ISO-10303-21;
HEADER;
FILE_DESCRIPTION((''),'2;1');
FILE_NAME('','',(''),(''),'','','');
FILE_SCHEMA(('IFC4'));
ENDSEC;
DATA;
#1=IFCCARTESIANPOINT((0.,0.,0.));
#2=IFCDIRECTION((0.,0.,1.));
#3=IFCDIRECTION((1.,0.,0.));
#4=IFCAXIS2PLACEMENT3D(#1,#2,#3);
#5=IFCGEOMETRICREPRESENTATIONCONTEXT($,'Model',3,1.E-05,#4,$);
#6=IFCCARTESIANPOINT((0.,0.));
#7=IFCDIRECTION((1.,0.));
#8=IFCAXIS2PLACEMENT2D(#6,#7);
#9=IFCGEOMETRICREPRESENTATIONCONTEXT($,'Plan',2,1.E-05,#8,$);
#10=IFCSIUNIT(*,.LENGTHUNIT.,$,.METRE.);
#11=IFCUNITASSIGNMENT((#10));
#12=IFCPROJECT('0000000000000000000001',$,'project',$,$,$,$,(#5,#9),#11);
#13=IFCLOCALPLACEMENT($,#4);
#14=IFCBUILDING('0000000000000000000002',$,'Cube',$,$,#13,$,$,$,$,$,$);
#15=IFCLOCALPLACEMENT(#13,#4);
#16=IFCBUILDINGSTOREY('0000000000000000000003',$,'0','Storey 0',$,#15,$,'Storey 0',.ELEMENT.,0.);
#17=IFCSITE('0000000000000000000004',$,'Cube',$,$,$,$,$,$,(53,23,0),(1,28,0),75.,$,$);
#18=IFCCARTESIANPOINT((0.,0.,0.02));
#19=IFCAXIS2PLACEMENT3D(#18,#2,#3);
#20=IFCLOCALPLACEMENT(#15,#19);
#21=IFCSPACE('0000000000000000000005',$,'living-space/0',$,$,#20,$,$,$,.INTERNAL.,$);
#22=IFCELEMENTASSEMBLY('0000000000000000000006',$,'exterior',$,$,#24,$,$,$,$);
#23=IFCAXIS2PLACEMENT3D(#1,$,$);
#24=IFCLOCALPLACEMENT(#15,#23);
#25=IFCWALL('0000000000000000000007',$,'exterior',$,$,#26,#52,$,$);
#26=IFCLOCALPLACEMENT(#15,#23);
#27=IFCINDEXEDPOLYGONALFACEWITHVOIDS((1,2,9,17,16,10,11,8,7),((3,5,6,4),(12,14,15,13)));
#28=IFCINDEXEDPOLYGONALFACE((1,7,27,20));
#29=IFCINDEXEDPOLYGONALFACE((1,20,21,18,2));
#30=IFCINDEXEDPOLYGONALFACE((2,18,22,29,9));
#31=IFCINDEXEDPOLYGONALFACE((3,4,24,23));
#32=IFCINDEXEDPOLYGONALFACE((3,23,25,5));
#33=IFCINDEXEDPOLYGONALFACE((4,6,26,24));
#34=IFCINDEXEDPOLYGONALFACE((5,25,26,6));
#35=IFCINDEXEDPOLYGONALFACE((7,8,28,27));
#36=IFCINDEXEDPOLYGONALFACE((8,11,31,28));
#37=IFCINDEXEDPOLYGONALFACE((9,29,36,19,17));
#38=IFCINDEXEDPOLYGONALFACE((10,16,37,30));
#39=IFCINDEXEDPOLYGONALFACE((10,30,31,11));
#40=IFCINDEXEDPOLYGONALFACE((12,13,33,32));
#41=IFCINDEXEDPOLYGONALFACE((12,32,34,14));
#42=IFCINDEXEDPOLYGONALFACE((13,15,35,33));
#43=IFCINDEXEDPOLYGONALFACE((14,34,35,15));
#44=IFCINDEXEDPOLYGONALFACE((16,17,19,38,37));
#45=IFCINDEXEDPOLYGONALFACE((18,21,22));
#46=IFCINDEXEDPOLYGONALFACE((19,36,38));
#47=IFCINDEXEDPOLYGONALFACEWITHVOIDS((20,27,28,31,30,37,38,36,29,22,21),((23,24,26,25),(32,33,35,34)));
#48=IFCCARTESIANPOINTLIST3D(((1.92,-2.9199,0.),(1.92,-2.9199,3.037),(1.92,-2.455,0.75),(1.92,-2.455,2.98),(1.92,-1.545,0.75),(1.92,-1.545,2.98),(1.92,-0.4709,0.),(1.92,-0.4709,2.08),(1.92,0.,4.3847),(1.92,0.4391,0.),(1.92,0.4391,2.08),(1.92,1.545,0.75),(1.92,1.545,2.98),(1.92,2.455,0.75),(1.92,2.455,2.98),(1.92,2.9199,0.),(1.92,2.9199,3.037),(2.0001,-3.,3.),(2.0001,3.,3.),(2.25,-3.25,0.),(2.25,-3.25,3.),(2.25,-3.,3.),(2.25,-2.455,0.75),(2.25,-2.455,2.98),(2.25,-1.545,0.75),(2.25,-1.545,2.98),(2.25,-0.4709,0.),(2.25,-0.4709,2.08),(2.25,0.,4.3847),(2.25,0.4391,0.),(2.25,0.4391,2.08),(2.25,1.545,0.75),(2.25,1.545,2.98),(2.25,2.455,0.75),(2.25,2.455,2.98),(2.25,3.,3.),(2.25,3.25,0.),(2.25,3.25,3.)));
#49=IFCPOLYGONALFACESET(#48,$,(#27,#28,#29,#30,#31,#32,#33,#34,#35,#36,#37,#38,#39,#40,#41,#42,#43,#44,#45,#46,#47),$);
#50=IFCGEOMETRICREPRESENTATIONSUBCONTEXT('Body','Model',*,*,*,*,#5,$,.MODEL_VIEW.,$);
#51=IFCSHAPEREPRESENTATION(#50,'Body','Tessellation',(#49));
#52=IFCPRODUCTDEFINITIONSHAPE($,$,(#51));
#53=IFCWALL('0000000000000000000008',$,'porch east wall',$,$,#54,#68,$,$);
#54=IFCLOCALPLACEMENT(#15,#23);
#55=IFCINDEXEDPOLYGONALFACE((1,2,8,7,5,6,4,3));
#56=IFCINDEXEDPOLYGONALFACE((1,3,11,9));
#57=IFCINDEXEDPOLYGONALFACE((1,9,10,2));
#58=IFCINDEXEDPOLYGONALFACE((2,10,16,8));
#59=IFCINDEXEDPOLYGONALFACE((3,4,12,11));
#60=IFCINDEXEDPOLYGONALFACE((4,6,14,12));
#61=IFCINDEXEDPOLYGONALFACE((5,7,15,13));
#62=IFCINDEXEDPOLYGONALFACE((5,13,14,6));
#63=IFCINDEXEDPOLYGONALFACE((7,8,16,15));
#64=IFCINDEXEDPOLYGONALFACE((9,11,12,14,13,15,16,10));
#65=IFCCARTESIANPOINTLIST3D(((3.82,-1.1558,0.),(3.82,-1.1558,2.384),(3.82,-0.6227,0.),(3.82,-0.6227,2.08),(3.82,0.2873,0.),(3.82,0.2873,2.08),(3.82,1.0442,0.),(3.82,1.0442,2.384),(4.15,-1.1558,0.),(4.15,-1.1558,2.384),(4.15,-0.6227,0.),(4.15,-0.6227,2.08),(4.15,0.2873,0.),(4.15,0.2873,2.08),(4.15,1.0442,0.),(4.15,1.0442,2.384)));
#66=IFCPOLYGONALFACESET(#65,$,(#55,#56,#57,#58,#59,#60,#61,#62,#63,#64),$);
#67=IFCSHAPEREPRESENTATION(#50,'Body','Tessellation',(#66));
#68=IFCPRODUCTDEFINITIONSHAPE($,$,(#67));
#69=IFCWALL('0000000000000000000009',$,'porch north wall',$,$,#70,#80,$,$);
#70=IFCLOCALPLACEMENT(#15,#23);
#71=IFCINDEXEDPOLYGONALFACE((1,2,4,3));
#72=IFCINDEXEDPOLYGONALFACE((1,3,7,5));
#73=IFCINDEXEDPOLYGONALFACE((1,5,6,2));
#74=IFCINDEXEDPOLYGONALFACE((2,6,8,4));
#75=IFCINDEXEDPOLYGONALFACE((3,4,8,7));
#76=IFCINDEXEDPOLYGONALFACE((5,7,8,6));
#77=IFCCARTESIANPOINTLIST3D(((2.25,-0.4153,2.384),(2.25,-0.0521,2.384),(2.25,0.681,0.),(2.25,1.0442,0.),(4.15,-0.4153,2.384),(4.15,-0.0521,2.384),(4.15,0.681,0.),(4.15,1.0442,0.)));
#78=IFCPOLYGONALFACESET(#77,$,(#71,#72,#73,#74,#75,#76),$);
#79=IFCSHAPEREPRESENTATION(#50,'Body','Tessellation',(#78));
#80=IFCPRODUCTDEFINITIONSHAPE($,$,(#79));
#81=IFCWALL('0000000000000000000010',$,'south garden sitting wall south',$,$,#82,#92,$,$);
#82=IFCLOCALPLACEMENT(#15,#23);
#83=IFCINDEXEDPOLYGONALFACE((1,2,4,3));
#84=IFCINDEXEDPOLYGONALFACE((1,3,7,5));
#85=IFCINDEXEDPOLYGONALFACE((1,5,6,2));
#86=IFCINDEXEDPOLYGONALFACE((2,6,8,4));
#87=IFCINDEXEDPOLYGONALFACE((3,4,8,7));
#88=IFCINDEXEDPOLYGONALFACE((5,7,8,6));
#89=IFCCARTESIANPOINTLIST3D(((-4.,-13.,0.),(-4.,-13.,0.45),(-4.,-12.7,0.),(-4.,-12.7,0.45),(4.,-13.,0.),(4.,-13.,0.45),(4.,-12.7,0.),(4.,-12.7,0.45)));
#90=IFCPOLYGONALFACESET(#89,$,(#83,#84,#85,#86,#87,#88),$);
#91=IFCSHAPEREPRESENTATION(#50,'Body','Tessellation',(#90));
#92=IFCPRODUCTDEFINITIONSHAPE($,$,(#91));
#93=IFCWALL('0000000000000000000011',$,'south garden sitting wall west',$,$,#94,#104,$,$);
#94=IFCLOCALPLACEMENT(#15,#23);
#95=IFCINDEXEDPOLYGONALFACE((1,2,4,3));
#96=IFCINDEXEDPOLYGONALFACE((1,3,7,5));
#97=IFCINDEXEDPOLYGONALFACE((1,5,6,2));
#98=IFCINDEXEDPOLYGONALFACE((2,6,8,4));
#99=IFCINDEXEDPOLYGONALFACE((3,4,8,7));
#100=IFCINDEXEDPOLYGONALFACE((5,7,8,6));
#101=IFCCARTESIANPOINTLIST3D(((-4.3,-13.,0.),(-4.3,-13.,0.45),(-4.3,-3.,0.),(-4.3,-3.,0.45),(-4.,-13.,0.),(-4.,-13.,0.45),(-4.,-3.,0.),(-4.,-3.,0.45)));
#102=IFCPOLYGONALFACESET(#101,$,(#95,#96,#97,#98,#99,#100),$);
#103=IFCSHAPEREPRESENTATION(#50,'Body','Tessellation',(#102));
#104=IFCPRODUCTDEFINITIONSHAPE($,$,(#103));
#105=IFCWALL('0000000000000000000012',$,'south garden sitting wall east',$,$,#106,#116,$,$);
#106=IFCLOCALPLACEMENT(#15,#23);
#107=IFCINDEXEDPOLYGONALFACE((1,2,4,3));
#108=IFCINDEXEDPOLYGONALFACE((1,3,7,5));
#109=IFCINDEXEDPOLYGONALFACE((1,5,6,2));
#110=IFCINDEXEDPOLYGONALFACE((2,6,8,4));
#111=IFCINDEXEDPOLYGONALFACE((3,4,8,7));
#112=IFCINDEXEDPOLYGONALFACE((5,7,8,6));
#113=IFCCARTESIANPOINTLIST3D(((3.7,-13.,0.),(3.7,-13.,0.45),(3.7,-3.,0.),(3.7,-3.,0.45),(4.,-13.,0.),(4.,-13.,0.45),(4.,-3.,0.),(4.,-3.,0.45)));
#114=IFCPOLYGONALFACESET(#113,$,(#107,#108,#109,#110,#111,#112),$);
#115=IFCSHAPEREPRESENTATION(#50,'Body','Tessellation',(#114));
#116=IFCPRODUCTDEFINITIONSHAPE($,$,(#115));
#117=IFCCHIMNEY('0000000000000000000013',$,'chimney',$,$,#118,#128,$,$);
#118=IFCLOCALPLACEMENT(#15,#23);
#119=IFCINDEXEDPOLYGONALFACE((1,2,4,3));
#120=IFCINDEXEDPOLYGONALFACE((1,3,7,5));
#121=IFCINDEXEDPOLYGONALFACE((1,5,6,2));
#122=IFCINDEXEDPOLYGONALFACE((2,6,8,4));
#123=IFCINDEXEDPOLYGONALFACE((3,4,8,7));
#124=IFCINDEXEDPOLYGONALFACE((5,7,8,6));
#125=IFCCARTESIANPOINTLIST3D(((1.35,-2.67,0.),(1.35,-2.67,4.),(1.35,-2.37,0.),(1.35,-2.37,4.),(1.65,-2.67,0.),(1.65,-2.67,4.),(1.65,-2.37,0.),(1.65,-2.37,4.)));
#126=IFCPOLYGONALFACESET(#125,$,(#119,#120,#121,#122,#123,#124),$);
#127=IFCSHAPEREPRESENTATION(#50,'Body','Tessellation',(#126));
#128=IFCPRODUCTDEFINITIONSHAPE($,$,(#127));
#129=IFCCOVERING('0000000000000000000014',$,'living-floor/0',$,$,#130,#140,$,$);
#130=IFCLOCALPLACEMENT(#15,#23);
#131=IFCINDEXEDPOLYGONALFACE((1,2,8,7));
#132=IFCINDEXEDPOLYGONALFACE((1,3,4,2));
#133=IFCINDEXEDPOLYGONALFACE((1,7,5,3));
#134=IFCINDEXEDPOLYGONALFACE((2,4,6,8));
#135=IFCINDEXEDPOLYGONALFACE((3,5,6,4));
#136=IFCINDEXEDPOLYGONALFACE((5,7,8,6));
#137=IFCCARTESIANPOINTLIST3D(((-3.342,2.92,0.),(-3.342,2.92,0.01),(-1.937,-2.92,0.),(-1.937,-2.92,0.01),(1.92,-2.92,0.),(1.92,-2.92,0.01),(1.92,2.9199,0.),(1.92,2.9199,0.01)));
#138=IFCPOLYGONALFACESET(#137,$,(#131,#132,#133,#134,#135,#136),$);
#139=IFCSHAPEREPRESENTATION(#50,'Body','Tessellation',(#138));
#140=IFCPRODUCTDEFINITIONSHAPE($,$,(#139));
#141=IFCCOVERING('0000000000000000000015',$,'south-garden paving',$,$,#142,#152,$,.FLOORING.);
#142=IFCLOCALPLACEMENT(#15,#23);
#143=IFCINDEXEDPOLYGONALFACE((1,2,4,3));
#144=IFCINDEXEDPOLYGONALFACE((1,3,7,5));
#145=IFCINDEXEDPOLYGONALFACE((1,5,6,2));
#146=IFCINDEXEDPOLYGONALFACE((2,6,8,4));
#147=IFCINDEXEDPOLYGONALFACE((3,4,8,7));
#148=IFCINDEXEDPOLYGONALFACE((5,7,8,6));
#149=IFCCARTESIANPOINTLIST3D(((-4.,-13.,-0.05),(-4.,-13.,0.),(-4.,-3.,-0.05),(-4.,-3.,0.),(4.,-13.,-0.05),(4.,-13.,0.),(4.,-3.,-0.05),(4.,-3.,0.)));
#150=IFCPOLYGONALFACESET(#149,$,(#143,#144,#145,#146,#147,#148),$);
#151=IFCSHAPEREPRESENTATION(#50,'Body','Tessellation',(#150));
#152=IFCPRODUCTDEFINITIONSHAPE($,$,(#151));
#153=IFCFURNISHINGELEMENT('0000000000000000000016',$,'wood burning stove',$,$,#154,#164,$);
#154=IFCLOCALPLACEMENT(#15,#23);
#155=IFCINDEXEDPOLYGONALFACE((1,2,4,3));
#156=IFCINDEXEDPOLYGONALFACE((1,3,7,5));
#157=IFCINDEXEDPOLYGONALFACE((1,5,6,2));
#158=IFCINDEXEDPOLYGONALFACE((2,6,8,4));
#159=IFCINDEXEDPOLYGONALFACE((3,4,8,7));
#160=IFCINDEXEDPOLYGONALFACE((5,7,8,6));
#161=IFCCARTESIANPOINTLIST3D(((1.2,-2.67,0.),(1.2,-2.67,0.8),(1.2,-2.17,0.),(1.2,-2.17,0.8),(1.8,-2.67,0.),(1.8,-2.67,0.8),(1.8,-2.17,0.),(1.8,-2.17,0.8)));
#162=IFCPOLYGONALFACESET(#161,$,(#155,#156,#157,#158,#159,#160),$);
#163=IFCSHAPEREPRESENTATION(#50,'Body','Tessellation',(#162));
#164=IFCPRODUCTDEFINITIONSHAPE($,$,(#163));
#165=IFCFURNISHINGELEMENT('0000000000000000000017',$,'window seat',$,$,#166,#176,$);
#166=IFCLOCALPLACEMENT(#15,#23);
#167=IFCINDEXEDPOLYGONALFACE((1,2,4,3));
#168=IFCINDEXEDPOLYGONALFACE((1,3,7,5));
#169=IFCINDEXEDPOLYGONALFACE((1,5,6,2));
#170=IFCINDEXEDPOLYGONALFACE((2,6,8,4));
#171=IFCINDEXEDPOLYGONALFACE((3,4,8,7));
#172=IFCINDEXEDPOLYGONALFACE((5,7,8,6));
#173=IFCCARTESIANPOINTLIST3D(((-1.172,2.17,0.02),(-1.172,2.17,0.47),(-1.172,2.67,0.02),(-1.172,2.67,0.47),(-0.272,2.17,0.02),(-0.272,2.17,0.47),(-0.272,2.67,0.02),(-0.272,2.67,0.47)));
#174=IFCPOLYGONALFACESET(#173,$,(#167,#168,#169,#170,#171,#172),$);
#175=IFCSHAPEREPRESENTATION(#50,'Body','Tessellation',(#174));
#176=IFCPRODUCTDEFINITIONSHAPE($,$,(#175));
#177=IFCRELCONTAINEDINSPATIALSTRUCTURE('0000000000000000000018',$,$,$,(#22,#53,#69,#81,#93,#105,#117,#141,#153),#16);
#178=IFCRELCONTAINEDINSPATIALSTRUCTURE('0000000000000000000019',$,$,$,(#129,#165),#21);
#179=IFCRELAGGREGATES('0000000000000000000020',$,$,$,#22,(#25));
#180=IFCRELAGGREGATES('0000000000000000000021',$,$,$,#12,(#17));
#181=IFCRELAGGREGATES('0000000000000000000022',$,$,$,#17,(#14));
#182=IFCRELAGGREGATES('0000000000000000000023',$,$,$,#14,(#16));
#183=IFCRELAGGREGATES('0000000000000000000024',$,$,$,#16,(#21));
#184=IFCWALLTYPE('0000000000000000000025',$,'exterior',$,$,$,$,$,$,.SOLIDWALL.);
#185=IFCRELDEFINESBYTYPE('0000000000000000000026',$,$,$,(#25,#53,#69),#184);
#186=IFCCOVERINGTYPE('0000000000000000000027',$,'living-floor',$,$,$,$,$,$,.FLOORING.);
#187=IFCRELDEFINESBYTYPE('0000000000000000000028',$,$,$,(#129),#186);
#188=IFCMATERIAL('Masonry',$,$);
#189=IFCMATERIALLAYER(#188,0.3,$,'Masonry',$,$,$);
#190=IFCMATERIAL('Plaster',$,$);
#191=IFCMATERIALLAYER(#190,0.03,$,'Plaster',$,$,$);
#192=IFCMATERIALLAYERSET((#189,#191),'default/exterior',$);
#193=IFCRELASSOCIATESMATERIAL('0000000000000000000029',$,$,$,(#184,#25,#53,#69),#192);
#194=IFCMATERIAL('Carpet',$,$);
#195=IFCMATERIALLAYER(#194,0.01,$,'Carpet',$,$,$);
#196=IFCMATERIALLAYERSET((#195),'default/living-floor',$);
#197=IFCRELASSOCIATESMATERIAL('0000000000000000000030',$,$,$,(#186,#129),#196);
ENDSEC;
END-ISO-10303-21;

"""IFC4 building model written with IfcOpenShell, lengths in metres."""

from ifc_helpers import new_model, si_unit, frame, origin, origin_with_axes, origin_2d_with_axis, place, context, subcontext, project, spatial, polyline, line, indexed_curve, outline, extrude, clip, bounded_halfspace, source, transform, mapped, material, layer, layer_set, layer_usage, type_object, element, aggregate, save


model = new_model("IFC4")

# Units and contexts
model_context = context("Model", 3, precision=1e-05, world=origin_with_axes())
plan_context = context("Plan", 2, precision=1e-05, world=origin_2d_with_axis())
body_context = subcontext(model_context, "Body", "Model", "MODEL_VIEW")
ifc_project = project(units=[si_unit("LENGTHUNIT", "METRE")], contexts=[model_context, plan_context])

# Site, building, storey
site = spatial("IfcSite", under=ifc_project, Name="Cube", RefLatitude=(53, 23, 0), RefLongitude=(1, 28, 0), RefElevation=75.0)
building_placement = place(None, origin_with_axes())
building = spatial("IfcBuilding", under=site, at=building_placement, Name="Cube")
storey_placement = place(building_placement, origin_with_axes())
storey = spatial("IfcBuildingStorey", under=building, at=storey_placement, Name="0", Description="Storey 0", LongName="Storey 0", CompositionType="ELEMENT", Elevation=0.0)

# Element assembly, wall, openings
ifc_material_1 = material(Name="Masonry")
ifc_layer_1 = layer(ifc_material_1, 0.3, Name="Masonry")
ifc_material_2 = material(Name="Plaster")
ifc_layer_2 = layer(ifc_material_2, 0.03, Name="Plaster")
ifc_layer_set_1 = layer_set([ifc_layer_1, ifc_layer_2], Name="default/exterior")
wall_type = type_object("IfcWallType", Name="exterior", PredefinedType="SOLIDWALL", material=ifc_layer_set_1)
assembly_1_placement = place(storey_placement, frame((2.0, -3.0, 0.0), z_axis=(0.0, 0.0, 1.0), x_axis=(0.0, 1.0, 0.0)))
assembly_1 = element("IfcElementAssembly", 1, at=assembly_1_placement, inside=storey, Name="exterior")
ifc_layer_usage_1 = layer_usage(ifc_layer_set_1, "AXIS2", "POSITIVE", -0.25)
wall_1_placement = place(assembly_1_placement, origin_with_axes())
wall_1 = element("IfcWall", 2, at=wall_1_placement, type_object=wall_type, material=ifc_layer_usage_1, Name="exterior", context=body_context, shape_type="Clipping", body=[
    clip(clip(clip(clip(extrude(outline(polyline([(0.0801, 0.08), (-0.25, -0.25), (6.25, -0.25), (5.9199, 0.08), (0.0801, 0.08)])), origin(), (0.0, 0.0, 1.0), 4.385), bounded_halfspace(frame((6.0, 0.0, 3.0), z_axis=(0.419069, 0.0, 0.907954), x_axis=(0.0, -1.0, 0.0)), False, origin(), polyline([(6.0, -1.0), (3.0, -1.0), (3.0, 1.0), (6.0, 1.0), (6.0, -1.0)]))), bounded_halfspace(frame((6.0, 0.0, 3.0), z_axis=(0.0, 0.0, 1.0), x_axis=(0.0, 1.0, 0.0)), False, origin(), polyline([(6.0, 1.0), (7.0, 1.0), (7.0, -1.0), (6.0, -1.0), (6.0, 1.0)]))), bounded_halfspace(frame((3.0, 0.0, 4.3847), z_axis=(-0.419069, 0.0, 0.907954), x_axis=(0.0, -1.0, 0.0)), False, origin(), polyline([(3.0, -1.0), (0.0, -1.0), (0.0, 1.0), (3.0, 1.0), (3.0, -1.0)]))), bounded_halfspace(frame((0.0, 0.0, 3.0), z_axis=(0.0, 0.0, 1.0), x_axis=(0.0, -1.0, 0.0)), False, origin(), polyline([(0.0, -1.0), (-1.0, -1.0), (-1.0, 1.0), (0.0, 1.0), (0.0, -1.0)]))),
])
opening_1_placement = place(wall_1_placement, frame((0.545, -0.25, 0.75), z_axis=(0.0, 0.0, 1.0), x_axis=(1.0, 0.0, 0.0)))
element("IfcOpeningElement", 3, at=opening_1_placement, cuts=wall_1, PredefinedType="OPENING", context=body_context, shape_type="SweptSolid", body=[
    extrude(outline(polyline([(0.0, -0.02), (0.91, -0.02), (0.91, 0.35), (0.0, 0.35), (0.0, -0.02)])), origin(), (0.0, 0.0, 1.0), 2.23),
])
opening_2_placement = place(wall_1_placement, frame((4.545, -0.25, 0.75), z_axis=(0.0, 0.0, 1.0), x_axis=(1.0, 0.0, 0.0)))
element("IfcOpeningElement", 4, at=opening_2_placement, cuts=wall_1, PredefinedType="OPENING", context=body_context, shape_type="SweptSolid", body=[
    extrude(outline(polyline([(0.0, -0.02), (0.91, -0.02), (0.91, 0.35), (0.0, 0.35), (0.0, -0.02)])), origin(), (0.0, 0.0, 1.0), 2.23),
])
shared_shape_1 = source(origin_with_axes(), body_context, "Body", "SweptSolid", [
    extrude(outline(indexed_curve([(0.0, 0.0), (0.91, 0.0), (0.91, 2.08), (0.0, 2.08)], segments=[line(1, 2, 3, 4, 1)])), frame((0.0, -0.6, 0.0), z_axis=(0.0, -1.0, 0.0), x_axis=(1.0, 0.0, 0.0)), (0.0, 0.0, -1.0), 1.2),
])
opening_3_placement = place(wall_1_placement, frame((2.5291, -0.25, 0.0), z_axis=(0.0, 0.0, 1.0), x_axis=(1.0, 0.0, 0.0)))
element("IfcOpeningElement", 5, at=opening_3_placement, cuts=wall_1, PredefinedType="OPENING", context=body_context, shape_type="MappedRepresentation", body=[
    mapped(shared_shape_1, transform((0.0, 0.0, 0.0), x_axis=(1.0, 0.0, 0.0), y_axis=(0.0, 1.0, 0.0), z_axis=(0.0, 0.0, 1.0), scale=1.0)),
])
aggregate(assembly_1, [wall_1])

# Wall, opening
ifc_layer_usage_2 = layer_usage(ifc_layer_set_1, "AXIS2", "POSITIVE", 0.0)
wall_2_placement = place(storey_placement, frame((4.15, -1.1558, 0.0), z_axis=(0.0, 0.0, 1.0), x_axis=(0.0, 1.0, 0.0)))
wall_2 = element("IfcWall", 6, at=wall_2_placement, inside=storey, type_object=wall_type, material=ifc_layer_usage_2, Name="porch east wall", context=body_context, shape_type="SweptSolid", body=[
    extrude(outline(indexed_curve([(0.0, 0.0), (0.0, 0.33), (2.2, 0.33), (2.2, 0.0), (0.0, 0.0)], self_intersect=False)), origin_with_axes(), (0.0, 0.0, 1.0), 2.384),
])
shared_shape_2 = source(origin_with_axes(), body_context, "Body", "SweptSolid", [
    extrude(outline(indexed_curve([(0.0, 0.0), (0.91, 0.0), (0.91, 2.08), (0.0, 2.08)], segments=[line(1, 2, 3, 4, 1)])), frame((0.0, -0.6, 0.0), z_axis=(0.0, -1.0, 0.0), x_axis=(1.0, 0.0, 0.0)), (0.0, 0.0, -1.0), 1.2),
])
opening_4_placement = place(wall_2_placement, frame((0.5331, 0.0, 0.0), z_axis=(0.0, 0.0, 1.0), x_axis=(1.0, 0.0, 0.0)))
element("IfcOpeningElement", 7, at=opening_4_placement, cuts=wall_2, PredefinedType="OPENING", context=body_context, shape_type="MappedRepresentation", body=[
    mapped(shared_shape_2, transform((0.0, 0.0, 0.0), x_axis=(1.0, 0.0, 0.0), y_axis=(0.0, 1.0, 0.0), z_axis=(0.0, 0.0, 1.0), scale=1.0)),
])

# Walls
ifc_layer_usage_3 = layer_usage(ifc_layer_set_1, "AXIS2", "POSITIVE", 0.0)
wall_3_placement = place(storey_placement, frame((4.15, 1.0442, 0.0), z_axis=(0.0, 0.0, 1.0), x_axis=(-1.0, 0.0, 0.0)))
element("IfcWall", 8, at=wall_3_placement, inside=storey, type_object=wall_type, material=ifc_layer_usage_3, Name="porch north wall", context=body_context, shape_type="SweptSolid", body=[
    extrude(outline(indexed_curve([(0.0, 0.0), (0.0, 0.3632), (1.9, 0.3632), (1.9, 0.0), (0.0, 0.0)], self_intersect=False)), origin_with_axes(), (0.0, 0.41778, 0.908548), 2.624),
])
wall_4_placement = place(storey_placement, frame((-4.0, -13.0, 0.0), z_axis=(0.0, 0.0, 1.0), x_axis=(1.0, 0.0, 0.0)))
element("IfcWall", 9, at=wall_4_placement, inside=storey, Name="south garden sitting wall south", context=body_context, shape_type="SweptSolid", body=[
    extrude(outline(indexed_curve([(0.0, 0.0), (0.0, 0.3), (8.0, 0.3), (8.0, 0.0), (0.0, 0.0)], self_intersect=False)), origin_with_axes(), (0.0, 0.0, 1.0), 0.45),
])
for number, where, z_axis, x_axis, name in (
    (10, (-4.0, -13.0, 0.0), (0.0, 0.0, 1.0), (0.0, 1.0, 0.0), "south garden sitting wall west"),
    (11, (4.0, -13.0, 0.0), (0.0, 0.0, 1.0), (0.0, 1.0, 0.0), "south garden sitting wall east"),
):
    element("IfcWall", number, at=place(storey_placement, frame(where, z_axis=z_axis, x_axis=x_axis)), inside=storey, Name=name, context=body_context, shape_type="SweptSolid", body=[
        extrude(outline(indexed_curve([(0.0, 0.0), (0.0, 0.3), (10.0, 0.3), (10.0, 0.0), (0.0, 0.0)], self_intersect=False)), origin_with_axes(), (0.0, 0.0, 1.0), 0.45),
    ])

# Chimney
chimney_placement = place(storey_placement, frame((1.35, -2.67, 0.0), z_axis=(0.0, 0.0, 1.0), x_axis=(1.0, 0.0, 0.0)))
element("IfcChimney", 12, at=chimney_placement, inside=storey, Name="chimney", context=body_context, shape_type="SweptSolid", body=[
    extrude(outline(indexed_curve([(0.0, 0.0), (0.3, 0.0), (0.3, 0.3), (0.0, 0.3)])), None, (0.0, 0.0, 1.0), 4.0),
])

# Shared definitions
space_placement = place(storey_placement, frame((0.0, 0.0, 0.02), z_axis=(0.0, 0.0, 1.0), x_axis=(1.0, 0.0, 0.0)))
space = spatial("IfcSpace", under=storey, at=space_placement, Name="living-space/0", PredefinedType="INTERNAL")

# Coverings
ifc_material_3 = material(Name="Carpet")
ifc_layer_3 = layer(ifc_material_3, 0.01, Name="Carpet")
ifc_layer_set_2 = layer_set([ifc_layer_3], Name="default/living-floor")
ifc_layer_usage_4 = layer_usage(ifc_layer_set_2, "AXIS3", "POSITIVE", 0.0)
covering_type = type_object("IfcCoveringType", Name="living-floor", PredefinedType="FLOORING", material=ifc_layer_set_2)
covering_1_placement = place(space_placement, frame((0.0, 0.0, -0.02), z_axis=(0.0, 0.0, 1.0), x_axis=(1.0, 0.0, 0.0)))
element("IfcCovering", 13, at=covering_1_placement, inside=space, type_object=covering_type, material=ifc_layer_usage_4, Name="living-floor/0", context=body_context, shape_type="SweptSolid", body=[
    extrude(outline(polyline([(1.92, 2.9199), (-3.342, 2.92), (-1.937, -2.92), (1.92, -2.92), (1.92, 2.9199)])), origin_with_axes(), (0.0, 0.0, 1.0), 0.01),
])
covering_2_placement = place(storey_placement, frame((-4.0, -13.0, 0.0), z_axis=(0.0, 0.0, 1.0), x_axis=(1.0, 0.0, 0.0)))
element("IfcCovering", 14, at=covering_2_placement, inside=storey, Name="south-garden paving", PredefinedType="FLOORING", context=body_context, shape_type="SweptSolid", body=[
    extrude(outline(indexed_curve([(0.0, 0.0), (8.0, 0.0), (8.0, 10.0), (0.0, 10.0)])), None, (0.0, 0.0, -1.0), 0.05),
])

# Furnishing elements
furnishing_1_placement = place(storey_placement, frame((1.2, -2.67, 0.0), z_axis=(0.0, 0.0, 1.0), x_axis=(1.0, 0.0, 0.0)))
element("IfcFurnishingElement", 15, at=furnishing_1_placement, inside=storey, Name="wood burning stove", context=body_context, shape_type="SweptSolid", body=[
    extrude(outline(indexed_curve([(0.0, 0.0), (0.6, 0.0), (0.6, 0.5), (0.0, 0.5)])), None, (0.0, 0.0, 1.0), 0.8),
])
furnishing_2_placement = place(space_placement, frame((-1.172, 2.17, 0.0), z_axis=(0.0, 0.0, 1.0), x_axis=(1.0, 0.0, 0.0)))
element("IfcFurnishingElement", 16, at=furnishing_2_placement, inside=space, Name="window seat", context=body_context, shape_type="SweptSolid", body=[
    extrude(outline(indexed_curve([(0.0, 0.0), (0.9, 0.0), (0.9, 0.5), (0.0, 0.5)])), None, (0.0, 0.0, 1.0), 0.45),
])

save(model, "model.ifc")
